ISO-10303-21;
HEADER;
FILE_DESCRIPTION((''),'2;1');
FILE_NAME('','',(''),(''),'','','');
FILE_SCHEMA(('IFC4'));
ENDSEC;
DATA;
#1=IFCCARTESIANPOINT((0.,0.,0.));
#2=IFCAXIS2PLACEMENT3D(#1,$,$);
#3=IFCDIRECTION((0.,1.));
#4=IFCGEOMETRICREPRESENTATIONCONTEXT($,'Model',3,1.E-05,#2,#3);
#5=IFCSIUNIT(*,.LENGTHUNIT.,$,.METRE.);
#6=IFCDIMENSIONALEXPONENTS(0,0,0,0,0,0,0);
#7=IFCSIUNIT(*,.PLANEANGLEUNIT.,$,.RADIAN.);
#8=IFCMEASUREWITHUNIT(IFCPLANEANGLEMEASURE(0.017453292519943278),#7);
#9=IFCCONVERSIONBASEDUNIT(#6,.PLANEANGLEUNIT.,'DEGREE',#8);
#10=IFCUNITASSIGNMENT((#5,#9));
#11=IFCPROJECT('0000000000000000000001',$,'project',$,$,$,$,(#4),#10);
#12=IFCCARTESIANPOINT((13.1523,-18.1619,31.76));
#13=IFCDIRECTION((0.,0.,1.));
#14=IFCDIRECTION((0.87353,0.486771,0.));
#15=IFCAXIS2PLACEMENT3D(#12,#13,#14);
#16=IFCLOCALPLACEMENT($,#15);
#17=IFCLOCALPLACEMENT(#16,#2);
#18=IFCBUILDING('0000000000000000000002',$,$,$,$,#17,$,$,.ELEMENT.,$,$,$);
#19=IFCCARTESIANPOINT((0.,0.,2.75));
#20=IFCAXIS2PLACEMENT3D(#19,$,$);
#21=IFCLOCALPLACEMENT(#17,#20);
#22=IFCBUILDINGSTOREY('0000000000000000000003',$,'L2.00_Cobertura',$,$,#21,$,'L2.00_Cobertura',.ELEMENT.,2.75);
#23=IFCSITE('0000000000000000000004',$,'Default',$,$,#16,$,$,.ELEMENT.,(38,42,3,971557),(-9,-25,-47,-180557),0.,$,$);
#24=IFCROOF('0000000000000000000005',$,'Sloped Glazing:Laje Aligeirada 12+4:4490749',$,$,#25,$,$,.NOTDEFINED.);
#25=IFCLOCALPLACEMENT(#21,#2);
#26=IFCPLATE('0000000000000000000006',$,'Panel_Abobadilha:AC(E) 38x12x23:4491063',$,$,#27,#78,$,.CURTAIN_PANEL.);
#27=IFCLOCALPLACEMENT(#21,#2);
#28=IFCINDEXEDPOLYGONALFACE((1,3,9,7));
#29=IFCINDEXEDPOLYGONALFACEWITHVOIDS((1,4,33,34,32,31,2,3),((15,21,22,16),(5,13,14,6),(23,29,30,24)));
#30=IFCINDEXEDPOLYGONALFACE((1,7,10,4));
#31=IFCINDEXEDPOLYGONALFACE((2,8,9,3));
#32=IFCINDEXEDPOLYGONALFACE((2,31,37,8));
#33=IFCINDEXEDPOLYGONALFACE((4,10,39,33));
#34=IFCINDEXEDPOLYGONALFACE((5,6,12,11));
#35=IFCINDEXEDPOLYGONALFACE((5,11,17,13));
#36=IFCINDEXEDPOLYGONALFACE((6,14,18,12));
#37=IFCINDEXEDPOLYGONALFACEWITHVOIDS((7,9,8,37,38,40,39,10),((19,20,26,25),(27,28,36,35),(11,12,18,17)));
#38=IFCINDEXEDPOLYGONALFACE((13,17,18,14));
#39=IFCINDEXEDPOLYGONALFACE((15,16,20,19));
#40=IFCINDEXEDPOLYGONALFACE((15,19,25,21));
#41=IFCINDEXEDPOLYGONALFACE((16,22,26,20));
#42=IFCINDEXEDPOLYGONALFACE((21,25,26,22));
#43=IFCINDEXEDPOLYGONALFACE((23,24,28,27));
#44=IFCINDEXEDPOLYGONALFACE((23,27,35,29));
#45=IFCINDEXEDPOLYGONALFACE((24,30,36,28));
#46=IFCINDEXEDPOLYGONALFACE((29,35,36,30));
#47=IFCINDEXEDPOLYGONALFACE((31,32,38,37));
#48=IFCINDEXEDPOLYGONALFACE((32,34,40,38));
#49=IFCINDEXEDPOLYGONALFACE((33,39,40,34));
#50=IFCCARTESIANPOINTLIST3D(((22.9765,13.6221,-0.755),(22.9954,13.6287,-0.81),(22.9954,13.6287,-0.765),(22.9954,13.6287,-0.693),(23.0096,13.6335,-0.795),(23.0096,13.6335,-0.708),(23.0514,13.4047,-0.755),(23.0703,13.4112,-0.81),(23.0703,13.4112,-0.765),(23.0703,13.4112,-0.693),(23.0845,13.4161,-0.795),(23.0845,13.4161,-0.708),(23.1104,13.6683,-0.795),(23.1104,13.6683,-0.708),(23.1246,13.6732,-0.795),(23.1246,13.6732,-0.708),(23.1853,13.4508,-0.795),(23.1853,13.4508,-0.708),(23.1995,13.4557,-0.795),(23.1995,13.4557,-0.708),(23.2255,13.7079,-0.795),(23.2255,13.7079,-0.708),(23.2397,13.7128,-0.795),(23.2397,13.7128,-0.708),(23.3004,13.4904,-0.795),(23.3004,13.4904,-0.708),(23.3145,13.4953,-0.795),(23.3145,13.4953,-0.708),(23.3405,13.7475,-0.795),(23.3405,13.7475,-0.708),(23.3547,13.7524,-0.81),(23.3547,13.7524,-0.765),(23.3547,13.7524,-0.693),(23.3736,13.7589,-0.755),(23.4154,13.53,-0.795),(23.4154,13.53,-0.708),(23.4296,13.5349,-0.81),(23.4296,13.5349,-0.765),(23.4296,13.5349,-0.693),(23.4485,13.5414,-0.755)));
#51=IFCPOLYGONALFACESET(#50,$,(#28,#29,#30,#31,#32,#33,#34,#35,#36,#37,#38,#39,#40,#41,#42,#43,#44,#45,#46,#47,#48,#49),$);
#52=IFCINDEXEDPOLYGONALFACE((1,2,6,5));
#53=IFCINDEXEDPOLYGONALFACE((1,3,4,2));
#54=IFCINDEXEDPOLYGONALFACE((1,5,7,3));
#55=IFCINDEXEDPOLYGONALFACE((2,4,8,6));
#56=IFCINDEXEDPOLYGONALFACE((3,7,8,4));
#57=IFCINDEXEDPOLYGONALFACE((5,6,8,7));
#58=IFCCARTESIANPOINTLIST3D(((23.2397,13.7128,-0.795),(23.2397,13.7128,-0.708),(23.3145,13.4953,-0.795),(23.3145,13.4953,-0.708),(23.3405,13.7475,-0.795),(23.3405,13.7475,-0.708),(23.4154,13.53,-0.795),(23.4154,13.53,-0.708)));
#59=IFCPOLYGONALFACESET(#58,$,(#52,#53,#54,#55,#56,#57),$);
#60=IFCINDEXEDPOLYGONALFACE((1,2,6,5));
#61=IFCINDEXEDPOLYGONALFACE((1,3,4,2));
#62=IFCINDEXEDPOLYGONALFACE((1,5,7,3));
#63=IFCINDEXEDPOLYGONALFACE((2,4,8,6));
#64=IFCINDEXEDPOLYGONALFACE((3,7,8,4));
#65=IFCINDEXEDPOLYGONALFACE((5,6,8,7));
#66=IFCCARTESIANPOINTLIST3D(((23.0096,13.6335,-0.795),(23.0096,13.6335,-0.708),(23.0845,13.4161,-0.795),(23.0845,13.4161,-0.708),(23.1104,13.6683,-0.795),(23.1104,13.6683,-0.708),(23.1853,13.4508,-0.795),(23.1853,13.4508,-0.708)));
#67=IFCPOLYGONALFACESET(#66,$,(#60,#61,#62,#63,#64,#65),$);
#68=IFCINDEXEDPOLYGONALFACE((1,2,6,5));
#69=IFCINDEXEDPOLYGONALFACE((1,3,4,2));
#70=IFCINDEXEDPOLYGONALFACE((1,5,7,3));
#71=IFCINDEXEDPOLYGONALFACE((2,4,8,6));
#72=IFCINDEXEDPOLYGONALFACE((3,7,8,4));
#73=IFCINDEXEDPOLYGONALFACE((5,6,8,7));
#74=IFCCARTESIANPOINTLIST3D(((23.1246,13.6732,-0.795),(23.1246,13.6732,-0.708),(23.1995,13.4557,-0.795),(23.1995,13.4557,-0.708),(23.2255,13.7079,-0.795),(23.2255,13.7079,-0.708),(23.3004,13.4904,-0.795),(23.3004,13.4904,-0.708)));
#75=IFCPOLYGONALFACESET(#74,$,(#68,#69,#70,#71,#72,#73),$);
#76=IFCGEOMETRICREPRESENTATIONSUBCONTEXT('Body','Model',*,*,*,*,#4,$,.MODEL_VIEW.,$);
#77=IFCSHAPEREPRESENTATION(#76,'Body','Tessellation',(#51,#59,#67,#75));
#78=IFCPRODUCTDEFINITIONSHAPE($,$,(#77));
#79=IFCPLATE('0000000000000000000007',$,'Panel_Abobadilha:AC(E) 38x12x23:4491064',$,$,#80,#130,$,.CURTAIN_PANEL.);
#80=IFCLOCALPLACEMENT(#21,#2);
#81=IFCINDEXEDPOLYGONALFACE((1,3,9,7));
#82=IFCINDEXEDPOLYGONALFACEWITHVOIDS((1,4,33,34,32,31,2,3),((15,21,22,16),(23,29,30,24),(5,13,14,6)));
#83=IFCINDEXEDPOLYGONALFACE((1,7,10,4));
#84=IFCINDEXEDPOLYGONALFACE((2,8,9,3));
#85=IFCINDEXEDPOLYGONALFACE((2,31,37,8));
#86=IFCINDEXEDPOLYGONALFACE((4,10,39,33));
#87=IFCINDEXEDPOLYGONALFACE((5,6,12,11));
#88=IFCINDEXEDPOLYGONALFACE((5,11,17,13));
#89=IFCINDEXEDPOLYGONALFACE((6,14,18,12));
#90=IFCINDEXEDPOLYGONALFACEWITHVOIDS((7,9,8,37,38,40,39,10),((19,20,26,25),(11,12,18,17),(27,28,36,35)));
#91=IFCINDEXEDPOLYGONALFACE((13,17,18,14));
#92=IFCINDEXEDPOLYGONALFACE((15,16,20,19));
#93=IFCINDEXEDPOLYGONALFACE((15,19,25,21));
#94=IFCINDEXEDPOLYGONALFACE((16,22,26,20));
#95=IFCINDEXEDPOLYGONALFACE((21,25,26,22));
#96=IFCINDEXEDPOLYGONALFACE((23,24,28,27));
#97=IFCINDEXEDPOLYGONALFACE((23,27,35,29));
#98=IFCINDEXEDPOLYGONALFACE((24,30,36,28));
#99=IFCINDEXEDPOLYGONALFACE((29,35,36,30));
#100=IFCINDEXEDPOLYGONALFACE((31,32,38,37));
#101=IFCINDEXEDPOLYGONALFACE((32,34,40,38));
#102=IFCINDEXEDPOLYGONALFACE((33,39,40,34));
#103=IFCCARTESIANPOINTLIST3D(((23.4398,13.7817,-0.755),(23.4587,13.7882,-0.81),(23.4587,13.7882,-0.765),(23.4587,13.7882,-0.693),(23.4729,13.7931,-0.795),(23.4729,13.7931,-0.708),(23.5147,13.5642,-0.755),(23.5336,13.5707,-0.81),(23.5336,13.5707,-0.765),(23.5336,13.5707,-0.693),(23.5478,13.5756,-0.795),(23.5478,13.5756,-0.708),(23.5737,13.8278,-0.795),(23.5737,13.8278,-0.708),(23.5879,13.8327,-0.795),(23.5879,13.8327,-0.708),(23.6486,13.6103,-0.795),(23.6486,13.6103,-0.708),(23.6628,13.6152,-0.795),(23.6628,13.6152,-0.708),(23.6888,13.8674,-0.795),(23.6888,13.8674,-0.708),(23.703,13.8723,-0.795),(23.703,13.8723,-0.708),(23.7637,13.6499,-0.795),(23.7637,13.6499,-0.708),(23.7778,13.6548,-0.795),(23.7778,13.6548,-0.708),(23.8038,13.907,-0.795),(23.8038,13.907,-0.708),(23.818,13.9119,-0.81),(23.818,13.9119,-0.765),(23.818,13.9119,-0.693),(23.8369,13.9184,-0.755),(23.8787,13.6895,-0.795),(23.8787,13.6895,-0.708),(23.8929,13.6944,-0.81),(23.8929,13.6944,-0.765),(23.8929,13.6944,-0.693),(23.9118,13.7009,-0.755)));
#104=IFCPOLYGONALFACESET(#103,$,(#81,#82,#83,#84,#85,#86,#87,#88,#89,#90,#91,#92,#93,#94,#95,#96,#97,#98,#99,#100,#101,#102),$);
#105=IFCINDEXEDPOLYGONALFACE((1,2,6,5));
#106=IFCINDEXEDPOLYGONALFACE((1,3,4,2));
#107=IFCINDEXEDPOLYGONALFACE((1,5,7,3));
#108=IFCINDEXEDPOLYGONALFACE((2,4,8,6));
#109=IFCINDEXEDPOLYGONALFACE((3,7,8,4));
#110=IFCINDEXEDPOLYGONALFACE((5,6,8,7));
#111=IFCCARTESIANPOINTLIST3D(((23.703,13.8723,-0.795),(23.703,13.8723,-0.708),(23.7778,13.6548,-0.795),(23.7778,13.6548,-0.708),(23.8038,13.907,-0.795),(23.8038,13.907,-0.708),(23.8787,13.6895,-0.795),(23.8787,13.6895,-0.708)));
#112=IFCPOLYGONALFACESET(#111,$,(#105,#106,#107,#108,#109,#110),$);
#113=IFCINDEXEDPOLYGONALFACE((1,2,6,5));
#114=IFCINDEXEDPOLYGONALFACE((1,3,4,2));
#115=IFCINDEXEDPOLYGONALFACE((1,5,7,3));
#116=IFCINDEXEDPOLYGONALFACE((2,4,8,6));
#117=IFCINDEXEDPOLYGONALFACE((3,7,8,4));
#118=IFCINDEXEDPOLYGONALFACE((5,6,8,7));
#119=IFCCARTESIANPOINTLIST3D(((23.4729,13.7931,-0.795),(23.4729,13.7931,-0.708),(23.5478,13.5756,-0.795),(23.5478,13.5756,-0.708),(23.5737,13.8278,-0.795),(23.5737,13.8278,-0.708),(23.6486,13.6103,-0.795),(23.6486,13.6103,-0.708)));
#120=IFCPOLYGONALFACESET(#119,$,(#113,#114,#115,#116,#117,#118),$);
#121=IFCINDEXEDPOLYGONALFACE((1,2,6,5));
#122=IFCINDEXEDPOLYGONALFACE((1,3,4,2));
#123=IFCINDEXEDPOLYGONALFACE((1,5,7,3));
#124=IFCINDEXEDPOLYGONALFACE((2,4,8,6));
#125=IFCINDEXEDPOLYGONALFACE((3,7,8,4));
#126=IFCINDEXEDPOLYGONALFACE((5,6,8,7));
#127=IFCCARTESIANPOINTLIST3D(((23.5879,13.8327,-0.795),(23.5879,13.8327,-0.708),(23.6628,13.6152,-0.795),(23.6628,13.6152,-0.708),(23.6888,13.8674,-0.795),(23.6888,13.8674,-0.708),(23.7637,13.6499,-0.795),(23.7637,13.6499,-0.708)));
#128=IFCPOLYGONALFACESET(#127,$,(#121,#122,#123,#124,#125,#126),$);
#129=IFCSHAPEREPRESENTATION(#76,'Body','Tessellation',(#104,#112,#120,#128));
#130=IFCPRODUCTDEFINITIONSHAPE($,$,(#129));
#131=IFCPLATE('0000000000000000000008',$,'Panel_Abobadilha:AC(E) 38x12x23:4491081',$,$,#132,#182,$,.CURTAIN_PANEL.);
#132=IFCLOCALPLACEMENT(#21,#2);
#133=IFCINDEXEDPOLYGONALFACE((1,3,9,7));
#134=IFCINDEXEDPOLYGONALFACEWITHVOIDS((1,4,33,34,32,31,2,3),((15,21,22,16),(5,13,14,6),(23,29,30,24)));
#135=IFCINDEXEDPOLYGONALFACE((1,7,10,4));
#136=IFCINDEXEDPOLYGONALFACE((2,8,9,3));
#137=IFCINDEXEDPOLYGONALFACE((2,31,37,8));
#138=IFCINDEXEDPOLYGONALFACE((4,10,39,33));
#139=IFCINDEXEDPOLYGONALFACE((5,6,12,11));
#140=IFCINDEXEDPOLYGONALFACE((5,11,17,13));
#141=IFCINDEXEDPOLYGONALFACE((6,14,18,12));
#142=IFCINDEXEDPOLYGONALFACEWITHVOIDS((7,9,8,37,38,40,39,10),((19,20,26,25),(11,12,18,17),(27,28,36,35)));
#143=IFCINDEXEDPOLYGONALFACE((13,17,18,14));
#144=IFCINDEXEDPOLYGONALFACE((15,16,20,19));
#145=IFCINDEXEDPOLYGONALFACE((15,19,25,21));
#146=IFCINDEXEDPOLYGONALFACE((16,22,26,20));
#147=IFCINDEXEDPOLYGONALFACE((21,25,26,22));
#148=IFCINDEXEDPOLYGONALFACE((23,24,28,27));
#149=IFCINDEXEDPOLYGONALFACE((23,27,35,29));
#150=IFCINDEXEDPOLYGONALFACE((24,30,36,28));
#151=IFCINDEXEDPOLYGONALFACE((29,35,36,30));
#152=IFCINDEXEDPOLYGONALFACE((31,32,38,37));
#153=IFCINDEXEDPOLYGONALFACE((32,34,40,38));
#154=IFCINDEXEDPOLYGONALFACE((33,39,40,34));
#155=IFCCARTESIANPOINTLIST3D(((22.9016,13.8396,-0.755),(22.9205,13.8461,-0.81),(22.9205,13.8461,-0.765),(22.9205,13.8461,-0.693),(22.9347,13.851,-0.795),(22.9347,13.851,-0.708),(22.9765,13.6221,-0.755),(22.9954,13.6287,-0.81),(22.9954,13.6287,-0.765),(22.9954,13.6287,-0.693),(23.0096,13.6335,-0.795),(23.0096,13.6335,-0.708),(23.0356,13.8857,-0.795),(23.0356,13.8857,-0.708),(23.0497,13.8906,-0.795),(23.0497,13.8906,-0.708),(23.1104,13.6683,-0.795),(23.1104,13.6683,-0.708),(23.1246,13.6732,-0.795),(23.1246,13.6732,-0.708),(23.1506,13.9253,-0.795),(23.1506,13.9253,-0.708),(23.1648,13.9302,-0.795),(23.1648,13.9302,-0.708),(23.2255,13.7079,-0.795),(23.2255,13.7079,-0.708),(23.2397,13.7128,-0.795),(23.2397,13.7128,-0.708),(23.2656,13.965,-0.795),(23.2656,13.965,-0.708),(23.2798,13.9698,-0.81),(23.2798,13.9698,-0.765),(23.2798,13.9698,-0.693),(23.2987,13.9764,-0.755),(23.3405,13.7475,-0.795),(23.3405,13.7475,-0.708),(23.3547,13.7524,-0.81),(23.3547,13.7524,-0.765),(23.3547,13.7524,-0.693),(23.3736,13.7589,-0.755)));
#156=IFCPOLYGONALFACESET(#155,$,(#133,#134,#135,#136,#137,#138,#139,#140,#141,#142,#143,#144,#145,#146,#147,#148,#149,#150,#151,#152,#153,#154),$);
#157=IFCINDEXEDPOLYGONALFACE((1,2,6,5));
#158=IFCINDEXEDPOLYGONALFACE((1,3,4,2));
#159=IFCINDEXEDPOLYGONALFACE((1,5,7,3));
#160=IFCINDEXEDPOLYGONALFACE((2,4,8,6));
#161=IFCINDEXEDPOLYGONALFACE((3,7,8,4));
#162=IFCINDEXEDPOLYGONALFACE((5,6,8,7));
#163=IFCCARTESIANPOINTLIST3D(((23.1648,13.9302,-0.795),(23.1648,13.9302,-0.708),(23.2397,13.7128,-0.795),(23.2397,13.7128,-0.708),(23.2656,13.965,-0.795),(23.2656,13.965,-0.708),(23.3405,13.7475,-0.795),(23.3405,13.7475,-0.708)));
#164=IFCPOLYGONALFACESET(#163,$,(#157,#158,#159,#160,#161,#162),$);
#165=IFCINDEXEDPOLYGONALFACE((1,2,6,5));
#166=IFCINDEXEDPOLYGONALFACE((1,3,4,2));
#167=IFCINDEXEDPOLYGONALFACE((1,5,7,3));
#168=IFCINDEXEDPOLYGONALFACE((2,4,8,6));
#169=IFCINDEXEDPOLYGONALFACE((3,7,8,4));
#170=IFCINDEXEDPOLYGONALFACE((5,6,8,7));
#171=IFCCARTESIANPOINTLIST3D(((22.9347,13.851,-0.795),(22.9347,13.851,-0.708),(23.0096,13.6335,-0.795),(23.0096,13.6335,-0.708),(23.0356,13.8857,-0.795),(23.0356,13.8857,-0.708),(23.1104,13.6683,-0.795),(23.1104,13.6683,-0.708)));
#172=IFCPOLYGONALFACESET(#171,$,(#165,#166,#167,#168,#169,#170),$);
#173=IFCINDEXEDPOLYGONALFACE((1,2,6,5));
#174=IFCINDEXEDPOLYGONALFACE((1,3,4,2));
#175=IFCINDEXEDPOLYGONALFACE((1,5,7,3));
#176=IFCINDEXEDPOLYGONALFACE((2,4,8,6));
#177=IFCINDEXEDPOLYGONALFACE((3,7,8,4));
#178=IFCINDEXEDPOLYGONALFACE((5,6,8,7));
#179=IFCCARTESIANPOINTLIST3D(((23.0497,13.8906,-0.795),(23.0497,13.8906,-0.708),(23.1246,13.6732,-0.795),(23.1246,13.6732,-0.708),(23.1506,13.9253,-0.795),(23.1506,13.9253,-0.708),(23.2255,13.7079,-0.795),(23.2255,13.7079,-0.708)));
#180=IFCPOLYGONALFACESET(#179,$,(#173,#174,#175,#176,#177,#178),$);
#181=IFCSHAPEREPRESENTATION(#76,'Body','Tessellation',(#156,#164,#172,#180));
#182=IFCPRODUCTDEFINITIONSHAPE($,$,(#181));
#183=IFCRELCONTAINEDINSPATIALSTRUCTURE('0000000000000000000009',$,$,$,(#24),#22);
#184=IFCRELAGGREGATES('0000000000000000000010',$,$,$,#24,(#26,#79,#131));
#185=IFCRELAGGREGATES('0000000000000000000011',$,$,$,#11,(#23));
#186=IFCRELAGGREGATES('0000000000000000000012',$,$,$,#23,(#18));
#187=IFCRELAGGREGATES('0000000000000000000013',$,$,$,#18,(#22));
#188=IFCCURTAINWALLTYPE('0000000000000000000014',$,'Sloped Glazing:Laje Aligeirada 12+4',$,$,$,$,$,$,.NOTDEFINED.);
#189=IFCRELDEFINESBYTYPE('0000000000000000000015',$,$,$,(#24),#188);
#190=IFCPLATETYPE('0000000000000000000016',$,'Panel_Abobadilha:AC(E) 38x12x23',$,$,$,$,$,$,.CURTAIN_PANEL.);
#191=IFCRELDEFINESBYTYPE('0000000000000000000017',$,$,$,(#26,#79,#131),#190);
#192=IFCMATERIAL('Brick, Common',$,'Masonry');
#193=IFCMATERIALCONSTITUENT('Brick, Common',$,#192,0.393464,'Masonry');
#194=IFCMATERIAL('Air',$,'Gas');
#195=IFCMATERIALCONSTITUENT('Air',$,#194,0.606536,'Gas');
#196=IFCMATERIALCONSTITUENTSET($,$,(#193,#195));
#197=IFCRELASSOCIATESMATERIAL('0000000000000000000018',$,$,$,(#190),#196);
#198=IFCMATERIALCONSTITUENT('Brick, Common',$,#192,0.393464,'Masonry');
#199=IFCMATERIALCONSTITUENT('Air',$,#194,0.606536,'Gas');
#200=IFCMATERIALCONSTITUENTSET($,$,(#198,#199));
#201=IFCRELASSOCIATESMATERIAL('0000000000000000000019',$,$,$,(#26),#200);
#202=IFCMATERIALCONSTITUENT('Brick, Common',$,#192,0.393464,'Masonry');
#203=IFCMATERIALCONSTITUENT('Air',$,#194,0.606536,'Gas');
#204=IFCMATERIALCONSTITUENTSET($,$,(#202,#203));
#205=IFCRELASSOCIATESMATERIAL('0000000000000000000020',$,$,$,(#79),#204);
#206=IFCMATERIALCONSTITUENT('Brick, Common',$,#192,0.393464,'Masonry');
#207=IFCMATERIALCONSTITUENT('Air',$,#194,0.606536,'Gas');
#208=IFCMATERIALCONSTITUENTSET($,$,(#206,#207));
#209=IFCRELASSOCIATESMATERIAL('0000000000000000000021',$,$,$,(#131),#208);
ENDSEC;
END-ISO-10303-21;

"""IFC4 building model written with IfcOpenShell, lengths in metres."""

from ifc_helpers import new_model, entity, si_unit, converted_unit, direction, frame, origin, place, context, subcontext, project, spatial, indexed_curve, outline, extrude, source, transform, mapped, material, constituent, constituent_set, type_object, type_shapes, element, aggregate, save


model = new_model("IFC4")

# Units and contexts
model_context = context("Model", 3, precision=1e-05, world=origin(), true_north=direction((0.0, 1.0)))
body_context = subcontext(model_context, "Body", "Model", "MODEL_VIEW")
ifc_project = project(units=[si_unit("LENGTHUNIT", "METRE"), converted_unit("PLANEANGLEUNIT", "DEGREE", entity("IfcPlaneAngleMeasure", 0.017453292519943278), si_unit("PLANEANGLEUNIT", "RADIAN"), dimensions=[0, 0, 0, 0, 0, 0, 0])], contexts=[model_context])

# Site, building, storey
site_placement = place(None, frame((13.1523, -18.1619, 31.76), z_axis=(0.0, 0.0, 1.0), x_axis=(0.87353, 0.486771, 0.0)))
site = spatial("IfcSite", under=ifc_project, at=site_placement, Name="Default", CompositionType="ELEMENT", RefLatitude=(38, 42, 3, 971557), RefLongitude=(-9, -25, -47, -180557), RefElevation=0.0)
building_placement = place(site_placement, origin())
building = spatial("IfcBuilding", under=site, at=building_placement, CompositionType="ELEMENT")
storey_placement = place(building_placement, frame((0.0, 0.0, 2.75)))
storey = spatial("IfcBuildingStorey", under=building, at=storey_placement, Name="L2.00_Cobertura", LongName="L2.00_Cobertura", CompositionType="ELEMENT", Elevation=2.75)

# Roof, plates
curtain_wall_type = type_object("IfcCurtainWallType", Name="Sloped Glazing:Laje Aligeirada 12+4", PredefinedType="NOTDEFINED")
roof_placement = place(storey_placement, frame((0.0, 0.0, -2.75)))
roof = element("IfcRoof", 1, at=roof_placement, inside=storey, type_object=curtain_wall_type, Name="Sloped Glazing:Laje Aligeirada 12+4:4490749", PredefinedType="NOTDEFINED")
ifc_material_1 = material(Name="Brick, Common", Category="Masonry")
ifc_material_2 = material(Name="Air", Category="Gas")
ifc_constituent_1 = constituent(ifc_material_1, Name="Brick, Common", Category="Masonry", fraction=0.393464)
ifc_constituent_2 = constituent(ifc_material_2, Name="Air", Category="Gas", fraction=0.606536)
ifc_constituent_set_1 = constituent_set(constituents=[ifc_constituent_1, ifc_constituent_2])
plate_type = type_object("IfcPlateType", Name="Panel_Abobadilha:AC(E) 38x12x23", PredefinedType="CURTAIN_PANEL", material=ifc_constituent_set_1)
shared_shape_1 = source(origin(), body_context, "Body", "SweptSolid", [
    extrude(outline(indexed_curve([(-0.19, -0.0543), (0.19, -0.0543), (0.19, -0.0093), (0.21, 0.0007), (0.19, 0.0628), (-0.19, 0.0628), (-0.21, 0.0007), (-0.19, -0.0093), (-0.19, -0.0543)], self_intersect=False), holes=[indexed_curve([(-0.0683, 0.0477), (-0.0683, -0.0393), (-0.175, -0.0393), (-0.175, 0.0477), (-0.0683, 0.0477)], self_intersect=False), indexed_curve([(0.0533, 0.0477), (0.0533, -0.0393), (-0.0533, -0.0393), (-0.0533, 0.0477), (0.0533, 0.0477)], self_intersect=False), indexed_curve([(0.175, 0.0477), (0.175, -0.0393), (0.0683, -0.0393), (0.0683, 0.0477), (0.175, 0.0477)], self_intersect=False)]), frame((0.0, 0.0543, 0.0)), (0.0, 0.0, 1.0), 0.23),
    extrude(outline(indexed_curve([(-0.0533, -0.0435), (0.0533, -0.0435), (0.0533, 0.0435), (-0.0533, 0.0435), (-0.0533, -0.0435)], self_intersect=False)), frame((0.1217, 0.0585, 0.0), z_axis=(0.0, 0.0, 1.0), x_axis=(-1.0, 0.0, 0.0)), (0.0, 0.0, 1.0), 0.23),
    extrude(outline(indexed_curve([(-0.0533, -0.0435), (0.0533, -0.0435), (0.0533, 0.0435), (-0.0533, 0.0435), (-0.0533, -0.0435)], self_intersect=False)), frame((-0.1217, 0.0585, 0.0), z_axis=(0.0, 0.0, 1.0), x_axis=(-1.0, 0.0, 0.0)), (0.0, 0.0, 1.0), 0.23),
    extrude(outline(indexed_curve([(-0.0533, -0.0435), (0.0533, -0.0435), (0.0533, 0.0435), (-0.0533, 0.0435), (-0.0533, -0.0435)], self_intersect=False)), frame((0.0, 0.0585, 0.0), z_axis=(0.0, 0.0, 1.0), x_axis=(-1.0, 0.0, 0.0)), (0.0, 0.0, 1.0), 0.23),
])
type_shapes(plate_type, [shared_shape_1])
ifc_constituent_3 = constituent(ifc_material_1, Name="Brick, Common", Category="Masonry", fraction=0.393464)
ifc_constituent_4 = constituent(ifc_material_2, Name="Air", Category="Gas", fraction=0.606536)
ifc_constituent_set_2 = constituent_set(constituents=[ifc_constituent_3, ifc_constituent_4])
plate_1_placement = place(roof_placement, frame((23.1751, 13.6905, 1.94), z_axis=(0.325568, -0.945519, 0.0), x_axis=(0.945519, 0.325568, 0.0)))
plate_1 = element("IfcPlate", 2, at=plate_1_placement, type_object=plate_type, material=ifc_constituent_set_2, Name="Panel_Abobadilha:AC(E) 38x12x23:4491063", PredefinedType="CURTAIN_PANEL", context=body_context, shape_type="MappedRepresentation", body=[
    mapped(shared_shape_1, transform((0.0, 0.0, 0.0), scale=1.0)),
])
ifc_constituent_5 = constituent(ifc_material_1, Name="Brick, Common", Category="Masonry", fraction=0.393464)
ifc_constituent_6 = constituent(ifc_material_2, Name="Air", Category="Gas", fraction=0.606536)
ifc_constituent_set_3 = constituent_set(constituents=[ifc_constituent_5, ifc_constituent_6])
plate_2_placement = place(roof_placement, frame((23.6384, 13.85, 1.94), z_axis=(0.325568, -0.945519, 0.0), x_axis=(0.945519, 0.325568, 0.0)))
plate_2 = element("IfcPlate", 3, at=plate_2_placement, type_object=plate_type, material=ifc_constituent_set_3, Name="Panel_Abobadilha:AC(E) 38x12x23:4491064", PredefinedType="CURTAIN_PANEL", context=body_context, shape_type="MappedRepresentation", body=[
    mapped(shared_shape_1, transform((0.0, 0.0, 0.0), scale=1.0)),
])
ifc_constituent_7 = constituent(ifc_material_1, Name="Brick, Common", Category="Masonry", fraction=0.393464)
ifc_constituent_8 = constituent(ifc_material_2, Name="Air", Category="Gas", fraction=0.606536)
ifc_constituent_set_4 = constituent_set(constituents=[ifc_constituent_7, ifc_constituent_8])
plate_3_placement = place(roof_placement, frame((23.1002, 13.908, 1.94), z_axis=(0.325568, -0.945519, 0.0), x_axis=(0.945519, 0.325568, 0.0)))
plate_3 = element("IfcPlate", 4, at=plate_3_placement, type_object=plate_type, material=ifc_constituent_set_4, Name="Panel_Abobadilha:AC(E) 38x12x23:4491081", PredefinedType="CURTAIN_PANEL", context=body_context, shape_type="MappedRepresentation", body=[
    mapped(shared_shape_1, transform((0.0, 0.0, 0.0), scale=1.0)),
])
aggregate(roof, [plate_1, plate_2, plate_3])

save(model, "model.ifc")
